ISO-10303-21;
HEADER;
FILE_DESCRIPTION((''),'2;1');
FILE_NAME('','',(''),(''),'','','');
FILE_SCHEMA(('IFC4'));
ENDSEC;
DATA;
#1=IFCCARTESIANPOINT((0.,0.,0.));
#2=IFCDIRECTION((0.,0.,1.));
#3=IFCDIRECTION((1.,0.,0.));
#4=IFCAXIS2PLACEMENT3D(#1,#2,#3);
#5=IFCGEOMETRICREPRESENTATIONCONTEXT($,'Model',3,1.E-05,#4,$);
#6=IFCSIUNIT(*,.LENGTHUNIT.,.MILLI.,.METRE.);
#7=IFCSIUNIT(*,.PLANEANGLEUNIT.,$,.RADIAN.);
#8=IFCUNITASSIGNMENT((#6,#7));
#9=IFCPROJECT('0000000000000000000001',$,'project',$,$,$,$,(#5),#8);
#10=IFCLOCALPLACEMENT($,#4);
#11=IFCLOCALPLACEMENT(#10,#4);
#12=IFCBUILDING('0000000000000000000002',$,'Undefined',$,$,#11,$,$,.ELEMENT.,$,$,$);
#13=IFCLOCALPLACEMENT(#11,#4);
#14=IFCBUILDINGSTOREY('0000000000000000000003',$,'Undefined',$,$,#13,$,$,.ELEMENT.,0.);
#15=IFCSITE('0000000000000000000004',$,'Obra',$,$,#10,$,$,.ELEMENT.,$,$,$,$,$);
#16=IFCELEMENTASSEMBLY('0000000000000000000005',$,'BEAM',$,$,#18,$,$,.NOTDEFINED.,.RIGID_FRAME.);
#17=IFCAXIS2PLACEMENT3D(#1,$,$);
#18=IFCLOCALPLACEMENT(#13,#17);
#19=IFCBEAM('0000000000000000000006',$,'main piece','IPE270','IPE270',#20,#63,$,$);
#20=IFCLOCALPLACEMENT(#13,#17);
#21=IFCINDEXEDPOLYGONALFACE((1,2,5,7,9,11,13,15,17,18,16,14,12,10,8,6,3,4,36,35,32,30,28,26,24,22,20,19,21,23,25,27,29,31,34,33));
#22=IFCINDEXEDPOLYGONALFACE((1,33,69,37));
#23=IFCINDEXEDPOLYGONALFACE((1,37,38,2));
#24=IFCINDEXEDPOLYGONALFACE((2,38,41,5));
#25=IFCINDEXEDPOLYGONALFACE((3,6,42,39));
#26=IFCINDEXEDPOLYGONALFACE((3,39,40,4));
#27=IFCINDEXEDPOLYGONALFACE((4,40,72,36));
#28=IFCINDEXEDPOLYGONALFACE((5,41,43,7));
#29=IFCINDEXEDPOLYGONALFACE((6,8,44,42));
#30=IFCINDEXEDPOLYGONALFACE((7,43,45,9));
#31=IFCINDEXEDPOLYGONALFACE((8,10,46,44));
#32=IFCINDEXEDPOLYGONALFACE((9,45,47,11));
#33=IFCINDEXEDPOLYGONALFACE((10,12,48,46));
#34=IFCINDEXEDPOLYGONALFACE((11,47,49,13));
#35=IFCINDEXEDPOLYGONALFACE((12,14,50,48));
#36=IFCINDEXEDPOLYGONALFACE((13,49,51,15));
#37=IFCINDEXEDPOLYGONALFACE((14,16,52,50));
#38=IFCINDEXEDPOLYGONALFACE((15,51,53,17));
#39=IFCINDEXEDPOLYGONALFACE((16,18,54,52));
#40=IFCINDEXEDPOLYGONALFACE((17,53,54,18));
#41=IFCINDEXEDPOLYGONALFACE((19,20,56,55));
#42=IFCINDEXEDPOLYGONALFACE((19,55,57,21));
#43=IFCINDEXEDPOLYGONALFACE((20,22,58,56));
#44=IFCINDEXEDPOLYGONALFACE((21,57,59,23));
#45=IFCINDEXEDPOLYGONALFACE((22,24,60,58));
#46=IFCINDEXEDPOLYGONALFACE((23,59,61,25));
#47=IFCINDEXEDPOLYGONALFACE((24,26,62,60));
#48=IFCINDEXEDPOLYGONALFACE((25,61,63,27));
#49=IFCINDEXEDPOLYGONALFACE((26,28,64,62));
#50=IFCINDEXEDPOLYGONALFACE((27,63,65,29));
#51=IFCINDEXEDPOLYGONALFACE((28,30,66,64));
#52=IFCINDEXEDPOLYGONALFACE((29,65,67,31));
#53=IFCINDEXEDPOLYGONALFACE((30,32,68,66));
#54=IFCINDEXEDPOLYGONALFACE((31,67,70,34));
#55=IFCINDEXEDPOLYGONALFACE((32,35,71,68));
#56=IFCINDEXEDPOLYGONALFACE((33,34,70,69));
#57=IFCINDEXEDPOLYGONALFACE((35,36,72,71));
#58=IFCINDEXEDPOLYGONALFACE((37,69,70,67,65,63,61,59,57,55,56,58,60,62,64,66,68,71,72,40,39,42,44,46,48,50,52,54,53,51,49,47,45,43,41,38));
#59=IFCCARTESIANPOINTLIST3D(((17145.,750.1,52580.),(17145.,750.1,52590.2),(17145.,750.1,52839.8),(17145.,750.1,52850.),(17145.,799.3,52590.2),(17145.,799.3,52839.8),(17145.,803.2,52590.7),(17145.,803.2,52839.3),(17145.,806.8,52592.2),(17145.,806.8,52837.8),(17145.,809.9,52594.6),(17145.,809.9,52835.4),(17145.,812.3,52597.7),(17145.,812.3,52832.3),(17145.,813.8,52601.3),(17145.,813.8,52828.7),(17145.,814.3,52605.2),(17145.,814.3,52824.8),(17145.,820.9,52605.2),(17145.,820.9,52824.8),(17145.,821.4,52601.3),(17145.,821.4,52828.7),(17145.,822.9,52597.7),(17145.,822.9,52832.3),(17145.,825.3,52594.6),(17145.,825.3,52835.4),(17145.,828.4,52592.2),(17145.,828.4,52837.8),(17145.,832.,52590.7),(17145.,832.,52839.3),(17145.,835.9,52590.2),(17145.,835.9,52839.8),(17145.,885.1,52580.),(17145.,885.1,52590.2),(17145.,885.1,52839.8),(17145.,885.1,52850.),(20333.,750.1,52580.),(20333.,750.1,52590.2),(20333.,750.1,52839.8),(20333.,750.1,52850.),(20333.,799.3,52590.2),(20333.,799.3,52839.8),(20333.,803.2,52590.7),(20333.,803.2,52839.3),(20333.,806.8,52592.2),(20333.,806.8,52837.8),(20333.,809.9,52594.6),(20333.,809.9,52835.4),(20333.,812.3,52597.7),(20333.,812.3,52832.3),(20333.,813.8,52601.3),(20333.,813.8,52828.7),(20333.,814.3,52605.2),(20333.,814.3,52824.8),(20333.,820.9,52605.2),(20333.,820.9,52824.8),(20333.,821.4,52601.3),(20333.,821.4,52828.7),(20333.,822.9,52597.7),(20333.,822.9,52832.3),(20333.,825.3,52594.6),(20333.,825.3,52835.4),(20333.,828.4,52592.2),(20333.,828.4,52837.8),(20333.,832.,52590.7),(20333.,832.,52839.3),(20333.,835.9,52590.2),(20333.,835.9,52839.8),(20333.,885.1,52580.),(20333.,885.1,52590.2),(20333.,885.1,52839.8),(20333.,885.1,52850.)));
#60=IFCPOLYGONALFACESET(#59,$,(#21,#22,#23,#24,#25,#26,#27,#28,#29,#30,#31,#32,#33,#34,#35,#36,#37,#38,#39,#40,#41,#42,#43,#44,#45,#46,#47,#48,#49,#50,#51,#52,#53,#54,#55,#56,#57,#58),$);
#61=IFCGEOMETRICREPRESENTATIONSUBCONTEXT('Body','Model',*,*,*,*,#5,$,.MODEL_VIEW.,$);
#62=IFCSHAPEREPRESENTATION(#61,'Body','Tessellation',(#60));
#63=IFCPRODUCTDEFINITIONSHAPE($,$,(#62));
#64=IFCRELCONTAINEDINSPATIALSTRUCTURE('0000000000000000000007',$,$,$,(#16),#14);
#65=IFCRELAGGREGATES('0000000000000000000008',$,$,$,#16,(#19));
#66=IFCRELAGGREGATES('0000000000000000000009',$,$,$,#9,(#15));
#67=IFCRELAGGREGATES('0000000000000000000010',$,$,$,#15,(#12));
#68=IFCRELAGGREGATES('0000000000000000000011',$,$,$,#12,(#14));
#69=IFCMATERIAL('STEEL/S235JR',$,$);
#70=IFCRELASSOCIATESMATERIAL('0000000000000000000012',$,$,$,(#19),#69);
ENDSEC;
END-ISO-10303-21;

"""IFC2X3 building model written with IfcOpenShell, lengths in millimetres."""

from ifc_helpers import new_model, si_unit, frame, origin_with_axes, origin_2d_with_axis, place, context, subcontext, project, spatial, i_section, extrude, material, element, aggregate, save


model = new_model("IFC2X3")

# Units and contexts
model_context = context("Model", 3, precision=1e-05, world=origin_with_axes())
body_context = subcontext(model_context, "Body", "Model", "MODEL_VIEW")
ifc_project = project(units=[si_unit("LENGTHUNIT", "METRE", prefix="MILLI"), si_unit("PLANEANGLEUNIT", "RADIAN")], contexts=[model_context])

# Site, building, storey
site_placement = place(None, origin_with_axes())
site = spatial("IfcSite", under=ifc_project, at=site_placement, Name="Obra", CompositionType="ELEMENT")
building_placement = place(site_placement, origin_with_axes())
building = spatial("IfcBuilding", under=site, at=building_placement, Name="Undefined", CompositionType="ELEMENT")
storey_placement = place(building_placement, origin_with_axes())
storey = spatial("IfcBuildingStorey", under=building, at=storey_placement, Name="Undefined", CompositionType="ELEMENT", Elevation=0.0)

# Shared definitions
ifc_material_1 = material(Name="STEEL/S235JR")

# Element assembly, beam
assembly_1_placement = place(storey_placement, origin_with_axes())
assembly_1 = element("IfcElementAssembly", 1, at=assembly_1_placement, inside=storey, Name="BEAM", AssemblyPlace="NOTDEFINED", PredefinedType="RIGID_FRAME")
beam_1_placement = place(assembly_1_placement, frame((17145.0, 817.6, 52715.0), z_axis=(0.0, 0.0, 1.0), x_axis=(1.0, 0.0, 0.0)))
beam_1 = element("IfcBeam", 2, at=beam_1_placement, material=ifc_material_1, Name="main piece", Description="IPE270", ObjectType="IPE270", context=body_context, shape_type="SweptSolid", body=[
    extrude(i_section(OverallWidth=135.0, OverallDepth=270.0, WebThickness=6.6, FlangeThickness=10.2, FilletRadius=15.0, at=origin_2d_with_axis()), frame((3188.0, 0.0, 0.0), z_axis=(-1.0, 0.0, 0.0), x_axis=(0.0, -1.0, 0.0)), (0.0, 0.0, 1.0), 3188.0),
])
aggregate(assembly_1, [beam_1])

save(model, "model.ifc")
